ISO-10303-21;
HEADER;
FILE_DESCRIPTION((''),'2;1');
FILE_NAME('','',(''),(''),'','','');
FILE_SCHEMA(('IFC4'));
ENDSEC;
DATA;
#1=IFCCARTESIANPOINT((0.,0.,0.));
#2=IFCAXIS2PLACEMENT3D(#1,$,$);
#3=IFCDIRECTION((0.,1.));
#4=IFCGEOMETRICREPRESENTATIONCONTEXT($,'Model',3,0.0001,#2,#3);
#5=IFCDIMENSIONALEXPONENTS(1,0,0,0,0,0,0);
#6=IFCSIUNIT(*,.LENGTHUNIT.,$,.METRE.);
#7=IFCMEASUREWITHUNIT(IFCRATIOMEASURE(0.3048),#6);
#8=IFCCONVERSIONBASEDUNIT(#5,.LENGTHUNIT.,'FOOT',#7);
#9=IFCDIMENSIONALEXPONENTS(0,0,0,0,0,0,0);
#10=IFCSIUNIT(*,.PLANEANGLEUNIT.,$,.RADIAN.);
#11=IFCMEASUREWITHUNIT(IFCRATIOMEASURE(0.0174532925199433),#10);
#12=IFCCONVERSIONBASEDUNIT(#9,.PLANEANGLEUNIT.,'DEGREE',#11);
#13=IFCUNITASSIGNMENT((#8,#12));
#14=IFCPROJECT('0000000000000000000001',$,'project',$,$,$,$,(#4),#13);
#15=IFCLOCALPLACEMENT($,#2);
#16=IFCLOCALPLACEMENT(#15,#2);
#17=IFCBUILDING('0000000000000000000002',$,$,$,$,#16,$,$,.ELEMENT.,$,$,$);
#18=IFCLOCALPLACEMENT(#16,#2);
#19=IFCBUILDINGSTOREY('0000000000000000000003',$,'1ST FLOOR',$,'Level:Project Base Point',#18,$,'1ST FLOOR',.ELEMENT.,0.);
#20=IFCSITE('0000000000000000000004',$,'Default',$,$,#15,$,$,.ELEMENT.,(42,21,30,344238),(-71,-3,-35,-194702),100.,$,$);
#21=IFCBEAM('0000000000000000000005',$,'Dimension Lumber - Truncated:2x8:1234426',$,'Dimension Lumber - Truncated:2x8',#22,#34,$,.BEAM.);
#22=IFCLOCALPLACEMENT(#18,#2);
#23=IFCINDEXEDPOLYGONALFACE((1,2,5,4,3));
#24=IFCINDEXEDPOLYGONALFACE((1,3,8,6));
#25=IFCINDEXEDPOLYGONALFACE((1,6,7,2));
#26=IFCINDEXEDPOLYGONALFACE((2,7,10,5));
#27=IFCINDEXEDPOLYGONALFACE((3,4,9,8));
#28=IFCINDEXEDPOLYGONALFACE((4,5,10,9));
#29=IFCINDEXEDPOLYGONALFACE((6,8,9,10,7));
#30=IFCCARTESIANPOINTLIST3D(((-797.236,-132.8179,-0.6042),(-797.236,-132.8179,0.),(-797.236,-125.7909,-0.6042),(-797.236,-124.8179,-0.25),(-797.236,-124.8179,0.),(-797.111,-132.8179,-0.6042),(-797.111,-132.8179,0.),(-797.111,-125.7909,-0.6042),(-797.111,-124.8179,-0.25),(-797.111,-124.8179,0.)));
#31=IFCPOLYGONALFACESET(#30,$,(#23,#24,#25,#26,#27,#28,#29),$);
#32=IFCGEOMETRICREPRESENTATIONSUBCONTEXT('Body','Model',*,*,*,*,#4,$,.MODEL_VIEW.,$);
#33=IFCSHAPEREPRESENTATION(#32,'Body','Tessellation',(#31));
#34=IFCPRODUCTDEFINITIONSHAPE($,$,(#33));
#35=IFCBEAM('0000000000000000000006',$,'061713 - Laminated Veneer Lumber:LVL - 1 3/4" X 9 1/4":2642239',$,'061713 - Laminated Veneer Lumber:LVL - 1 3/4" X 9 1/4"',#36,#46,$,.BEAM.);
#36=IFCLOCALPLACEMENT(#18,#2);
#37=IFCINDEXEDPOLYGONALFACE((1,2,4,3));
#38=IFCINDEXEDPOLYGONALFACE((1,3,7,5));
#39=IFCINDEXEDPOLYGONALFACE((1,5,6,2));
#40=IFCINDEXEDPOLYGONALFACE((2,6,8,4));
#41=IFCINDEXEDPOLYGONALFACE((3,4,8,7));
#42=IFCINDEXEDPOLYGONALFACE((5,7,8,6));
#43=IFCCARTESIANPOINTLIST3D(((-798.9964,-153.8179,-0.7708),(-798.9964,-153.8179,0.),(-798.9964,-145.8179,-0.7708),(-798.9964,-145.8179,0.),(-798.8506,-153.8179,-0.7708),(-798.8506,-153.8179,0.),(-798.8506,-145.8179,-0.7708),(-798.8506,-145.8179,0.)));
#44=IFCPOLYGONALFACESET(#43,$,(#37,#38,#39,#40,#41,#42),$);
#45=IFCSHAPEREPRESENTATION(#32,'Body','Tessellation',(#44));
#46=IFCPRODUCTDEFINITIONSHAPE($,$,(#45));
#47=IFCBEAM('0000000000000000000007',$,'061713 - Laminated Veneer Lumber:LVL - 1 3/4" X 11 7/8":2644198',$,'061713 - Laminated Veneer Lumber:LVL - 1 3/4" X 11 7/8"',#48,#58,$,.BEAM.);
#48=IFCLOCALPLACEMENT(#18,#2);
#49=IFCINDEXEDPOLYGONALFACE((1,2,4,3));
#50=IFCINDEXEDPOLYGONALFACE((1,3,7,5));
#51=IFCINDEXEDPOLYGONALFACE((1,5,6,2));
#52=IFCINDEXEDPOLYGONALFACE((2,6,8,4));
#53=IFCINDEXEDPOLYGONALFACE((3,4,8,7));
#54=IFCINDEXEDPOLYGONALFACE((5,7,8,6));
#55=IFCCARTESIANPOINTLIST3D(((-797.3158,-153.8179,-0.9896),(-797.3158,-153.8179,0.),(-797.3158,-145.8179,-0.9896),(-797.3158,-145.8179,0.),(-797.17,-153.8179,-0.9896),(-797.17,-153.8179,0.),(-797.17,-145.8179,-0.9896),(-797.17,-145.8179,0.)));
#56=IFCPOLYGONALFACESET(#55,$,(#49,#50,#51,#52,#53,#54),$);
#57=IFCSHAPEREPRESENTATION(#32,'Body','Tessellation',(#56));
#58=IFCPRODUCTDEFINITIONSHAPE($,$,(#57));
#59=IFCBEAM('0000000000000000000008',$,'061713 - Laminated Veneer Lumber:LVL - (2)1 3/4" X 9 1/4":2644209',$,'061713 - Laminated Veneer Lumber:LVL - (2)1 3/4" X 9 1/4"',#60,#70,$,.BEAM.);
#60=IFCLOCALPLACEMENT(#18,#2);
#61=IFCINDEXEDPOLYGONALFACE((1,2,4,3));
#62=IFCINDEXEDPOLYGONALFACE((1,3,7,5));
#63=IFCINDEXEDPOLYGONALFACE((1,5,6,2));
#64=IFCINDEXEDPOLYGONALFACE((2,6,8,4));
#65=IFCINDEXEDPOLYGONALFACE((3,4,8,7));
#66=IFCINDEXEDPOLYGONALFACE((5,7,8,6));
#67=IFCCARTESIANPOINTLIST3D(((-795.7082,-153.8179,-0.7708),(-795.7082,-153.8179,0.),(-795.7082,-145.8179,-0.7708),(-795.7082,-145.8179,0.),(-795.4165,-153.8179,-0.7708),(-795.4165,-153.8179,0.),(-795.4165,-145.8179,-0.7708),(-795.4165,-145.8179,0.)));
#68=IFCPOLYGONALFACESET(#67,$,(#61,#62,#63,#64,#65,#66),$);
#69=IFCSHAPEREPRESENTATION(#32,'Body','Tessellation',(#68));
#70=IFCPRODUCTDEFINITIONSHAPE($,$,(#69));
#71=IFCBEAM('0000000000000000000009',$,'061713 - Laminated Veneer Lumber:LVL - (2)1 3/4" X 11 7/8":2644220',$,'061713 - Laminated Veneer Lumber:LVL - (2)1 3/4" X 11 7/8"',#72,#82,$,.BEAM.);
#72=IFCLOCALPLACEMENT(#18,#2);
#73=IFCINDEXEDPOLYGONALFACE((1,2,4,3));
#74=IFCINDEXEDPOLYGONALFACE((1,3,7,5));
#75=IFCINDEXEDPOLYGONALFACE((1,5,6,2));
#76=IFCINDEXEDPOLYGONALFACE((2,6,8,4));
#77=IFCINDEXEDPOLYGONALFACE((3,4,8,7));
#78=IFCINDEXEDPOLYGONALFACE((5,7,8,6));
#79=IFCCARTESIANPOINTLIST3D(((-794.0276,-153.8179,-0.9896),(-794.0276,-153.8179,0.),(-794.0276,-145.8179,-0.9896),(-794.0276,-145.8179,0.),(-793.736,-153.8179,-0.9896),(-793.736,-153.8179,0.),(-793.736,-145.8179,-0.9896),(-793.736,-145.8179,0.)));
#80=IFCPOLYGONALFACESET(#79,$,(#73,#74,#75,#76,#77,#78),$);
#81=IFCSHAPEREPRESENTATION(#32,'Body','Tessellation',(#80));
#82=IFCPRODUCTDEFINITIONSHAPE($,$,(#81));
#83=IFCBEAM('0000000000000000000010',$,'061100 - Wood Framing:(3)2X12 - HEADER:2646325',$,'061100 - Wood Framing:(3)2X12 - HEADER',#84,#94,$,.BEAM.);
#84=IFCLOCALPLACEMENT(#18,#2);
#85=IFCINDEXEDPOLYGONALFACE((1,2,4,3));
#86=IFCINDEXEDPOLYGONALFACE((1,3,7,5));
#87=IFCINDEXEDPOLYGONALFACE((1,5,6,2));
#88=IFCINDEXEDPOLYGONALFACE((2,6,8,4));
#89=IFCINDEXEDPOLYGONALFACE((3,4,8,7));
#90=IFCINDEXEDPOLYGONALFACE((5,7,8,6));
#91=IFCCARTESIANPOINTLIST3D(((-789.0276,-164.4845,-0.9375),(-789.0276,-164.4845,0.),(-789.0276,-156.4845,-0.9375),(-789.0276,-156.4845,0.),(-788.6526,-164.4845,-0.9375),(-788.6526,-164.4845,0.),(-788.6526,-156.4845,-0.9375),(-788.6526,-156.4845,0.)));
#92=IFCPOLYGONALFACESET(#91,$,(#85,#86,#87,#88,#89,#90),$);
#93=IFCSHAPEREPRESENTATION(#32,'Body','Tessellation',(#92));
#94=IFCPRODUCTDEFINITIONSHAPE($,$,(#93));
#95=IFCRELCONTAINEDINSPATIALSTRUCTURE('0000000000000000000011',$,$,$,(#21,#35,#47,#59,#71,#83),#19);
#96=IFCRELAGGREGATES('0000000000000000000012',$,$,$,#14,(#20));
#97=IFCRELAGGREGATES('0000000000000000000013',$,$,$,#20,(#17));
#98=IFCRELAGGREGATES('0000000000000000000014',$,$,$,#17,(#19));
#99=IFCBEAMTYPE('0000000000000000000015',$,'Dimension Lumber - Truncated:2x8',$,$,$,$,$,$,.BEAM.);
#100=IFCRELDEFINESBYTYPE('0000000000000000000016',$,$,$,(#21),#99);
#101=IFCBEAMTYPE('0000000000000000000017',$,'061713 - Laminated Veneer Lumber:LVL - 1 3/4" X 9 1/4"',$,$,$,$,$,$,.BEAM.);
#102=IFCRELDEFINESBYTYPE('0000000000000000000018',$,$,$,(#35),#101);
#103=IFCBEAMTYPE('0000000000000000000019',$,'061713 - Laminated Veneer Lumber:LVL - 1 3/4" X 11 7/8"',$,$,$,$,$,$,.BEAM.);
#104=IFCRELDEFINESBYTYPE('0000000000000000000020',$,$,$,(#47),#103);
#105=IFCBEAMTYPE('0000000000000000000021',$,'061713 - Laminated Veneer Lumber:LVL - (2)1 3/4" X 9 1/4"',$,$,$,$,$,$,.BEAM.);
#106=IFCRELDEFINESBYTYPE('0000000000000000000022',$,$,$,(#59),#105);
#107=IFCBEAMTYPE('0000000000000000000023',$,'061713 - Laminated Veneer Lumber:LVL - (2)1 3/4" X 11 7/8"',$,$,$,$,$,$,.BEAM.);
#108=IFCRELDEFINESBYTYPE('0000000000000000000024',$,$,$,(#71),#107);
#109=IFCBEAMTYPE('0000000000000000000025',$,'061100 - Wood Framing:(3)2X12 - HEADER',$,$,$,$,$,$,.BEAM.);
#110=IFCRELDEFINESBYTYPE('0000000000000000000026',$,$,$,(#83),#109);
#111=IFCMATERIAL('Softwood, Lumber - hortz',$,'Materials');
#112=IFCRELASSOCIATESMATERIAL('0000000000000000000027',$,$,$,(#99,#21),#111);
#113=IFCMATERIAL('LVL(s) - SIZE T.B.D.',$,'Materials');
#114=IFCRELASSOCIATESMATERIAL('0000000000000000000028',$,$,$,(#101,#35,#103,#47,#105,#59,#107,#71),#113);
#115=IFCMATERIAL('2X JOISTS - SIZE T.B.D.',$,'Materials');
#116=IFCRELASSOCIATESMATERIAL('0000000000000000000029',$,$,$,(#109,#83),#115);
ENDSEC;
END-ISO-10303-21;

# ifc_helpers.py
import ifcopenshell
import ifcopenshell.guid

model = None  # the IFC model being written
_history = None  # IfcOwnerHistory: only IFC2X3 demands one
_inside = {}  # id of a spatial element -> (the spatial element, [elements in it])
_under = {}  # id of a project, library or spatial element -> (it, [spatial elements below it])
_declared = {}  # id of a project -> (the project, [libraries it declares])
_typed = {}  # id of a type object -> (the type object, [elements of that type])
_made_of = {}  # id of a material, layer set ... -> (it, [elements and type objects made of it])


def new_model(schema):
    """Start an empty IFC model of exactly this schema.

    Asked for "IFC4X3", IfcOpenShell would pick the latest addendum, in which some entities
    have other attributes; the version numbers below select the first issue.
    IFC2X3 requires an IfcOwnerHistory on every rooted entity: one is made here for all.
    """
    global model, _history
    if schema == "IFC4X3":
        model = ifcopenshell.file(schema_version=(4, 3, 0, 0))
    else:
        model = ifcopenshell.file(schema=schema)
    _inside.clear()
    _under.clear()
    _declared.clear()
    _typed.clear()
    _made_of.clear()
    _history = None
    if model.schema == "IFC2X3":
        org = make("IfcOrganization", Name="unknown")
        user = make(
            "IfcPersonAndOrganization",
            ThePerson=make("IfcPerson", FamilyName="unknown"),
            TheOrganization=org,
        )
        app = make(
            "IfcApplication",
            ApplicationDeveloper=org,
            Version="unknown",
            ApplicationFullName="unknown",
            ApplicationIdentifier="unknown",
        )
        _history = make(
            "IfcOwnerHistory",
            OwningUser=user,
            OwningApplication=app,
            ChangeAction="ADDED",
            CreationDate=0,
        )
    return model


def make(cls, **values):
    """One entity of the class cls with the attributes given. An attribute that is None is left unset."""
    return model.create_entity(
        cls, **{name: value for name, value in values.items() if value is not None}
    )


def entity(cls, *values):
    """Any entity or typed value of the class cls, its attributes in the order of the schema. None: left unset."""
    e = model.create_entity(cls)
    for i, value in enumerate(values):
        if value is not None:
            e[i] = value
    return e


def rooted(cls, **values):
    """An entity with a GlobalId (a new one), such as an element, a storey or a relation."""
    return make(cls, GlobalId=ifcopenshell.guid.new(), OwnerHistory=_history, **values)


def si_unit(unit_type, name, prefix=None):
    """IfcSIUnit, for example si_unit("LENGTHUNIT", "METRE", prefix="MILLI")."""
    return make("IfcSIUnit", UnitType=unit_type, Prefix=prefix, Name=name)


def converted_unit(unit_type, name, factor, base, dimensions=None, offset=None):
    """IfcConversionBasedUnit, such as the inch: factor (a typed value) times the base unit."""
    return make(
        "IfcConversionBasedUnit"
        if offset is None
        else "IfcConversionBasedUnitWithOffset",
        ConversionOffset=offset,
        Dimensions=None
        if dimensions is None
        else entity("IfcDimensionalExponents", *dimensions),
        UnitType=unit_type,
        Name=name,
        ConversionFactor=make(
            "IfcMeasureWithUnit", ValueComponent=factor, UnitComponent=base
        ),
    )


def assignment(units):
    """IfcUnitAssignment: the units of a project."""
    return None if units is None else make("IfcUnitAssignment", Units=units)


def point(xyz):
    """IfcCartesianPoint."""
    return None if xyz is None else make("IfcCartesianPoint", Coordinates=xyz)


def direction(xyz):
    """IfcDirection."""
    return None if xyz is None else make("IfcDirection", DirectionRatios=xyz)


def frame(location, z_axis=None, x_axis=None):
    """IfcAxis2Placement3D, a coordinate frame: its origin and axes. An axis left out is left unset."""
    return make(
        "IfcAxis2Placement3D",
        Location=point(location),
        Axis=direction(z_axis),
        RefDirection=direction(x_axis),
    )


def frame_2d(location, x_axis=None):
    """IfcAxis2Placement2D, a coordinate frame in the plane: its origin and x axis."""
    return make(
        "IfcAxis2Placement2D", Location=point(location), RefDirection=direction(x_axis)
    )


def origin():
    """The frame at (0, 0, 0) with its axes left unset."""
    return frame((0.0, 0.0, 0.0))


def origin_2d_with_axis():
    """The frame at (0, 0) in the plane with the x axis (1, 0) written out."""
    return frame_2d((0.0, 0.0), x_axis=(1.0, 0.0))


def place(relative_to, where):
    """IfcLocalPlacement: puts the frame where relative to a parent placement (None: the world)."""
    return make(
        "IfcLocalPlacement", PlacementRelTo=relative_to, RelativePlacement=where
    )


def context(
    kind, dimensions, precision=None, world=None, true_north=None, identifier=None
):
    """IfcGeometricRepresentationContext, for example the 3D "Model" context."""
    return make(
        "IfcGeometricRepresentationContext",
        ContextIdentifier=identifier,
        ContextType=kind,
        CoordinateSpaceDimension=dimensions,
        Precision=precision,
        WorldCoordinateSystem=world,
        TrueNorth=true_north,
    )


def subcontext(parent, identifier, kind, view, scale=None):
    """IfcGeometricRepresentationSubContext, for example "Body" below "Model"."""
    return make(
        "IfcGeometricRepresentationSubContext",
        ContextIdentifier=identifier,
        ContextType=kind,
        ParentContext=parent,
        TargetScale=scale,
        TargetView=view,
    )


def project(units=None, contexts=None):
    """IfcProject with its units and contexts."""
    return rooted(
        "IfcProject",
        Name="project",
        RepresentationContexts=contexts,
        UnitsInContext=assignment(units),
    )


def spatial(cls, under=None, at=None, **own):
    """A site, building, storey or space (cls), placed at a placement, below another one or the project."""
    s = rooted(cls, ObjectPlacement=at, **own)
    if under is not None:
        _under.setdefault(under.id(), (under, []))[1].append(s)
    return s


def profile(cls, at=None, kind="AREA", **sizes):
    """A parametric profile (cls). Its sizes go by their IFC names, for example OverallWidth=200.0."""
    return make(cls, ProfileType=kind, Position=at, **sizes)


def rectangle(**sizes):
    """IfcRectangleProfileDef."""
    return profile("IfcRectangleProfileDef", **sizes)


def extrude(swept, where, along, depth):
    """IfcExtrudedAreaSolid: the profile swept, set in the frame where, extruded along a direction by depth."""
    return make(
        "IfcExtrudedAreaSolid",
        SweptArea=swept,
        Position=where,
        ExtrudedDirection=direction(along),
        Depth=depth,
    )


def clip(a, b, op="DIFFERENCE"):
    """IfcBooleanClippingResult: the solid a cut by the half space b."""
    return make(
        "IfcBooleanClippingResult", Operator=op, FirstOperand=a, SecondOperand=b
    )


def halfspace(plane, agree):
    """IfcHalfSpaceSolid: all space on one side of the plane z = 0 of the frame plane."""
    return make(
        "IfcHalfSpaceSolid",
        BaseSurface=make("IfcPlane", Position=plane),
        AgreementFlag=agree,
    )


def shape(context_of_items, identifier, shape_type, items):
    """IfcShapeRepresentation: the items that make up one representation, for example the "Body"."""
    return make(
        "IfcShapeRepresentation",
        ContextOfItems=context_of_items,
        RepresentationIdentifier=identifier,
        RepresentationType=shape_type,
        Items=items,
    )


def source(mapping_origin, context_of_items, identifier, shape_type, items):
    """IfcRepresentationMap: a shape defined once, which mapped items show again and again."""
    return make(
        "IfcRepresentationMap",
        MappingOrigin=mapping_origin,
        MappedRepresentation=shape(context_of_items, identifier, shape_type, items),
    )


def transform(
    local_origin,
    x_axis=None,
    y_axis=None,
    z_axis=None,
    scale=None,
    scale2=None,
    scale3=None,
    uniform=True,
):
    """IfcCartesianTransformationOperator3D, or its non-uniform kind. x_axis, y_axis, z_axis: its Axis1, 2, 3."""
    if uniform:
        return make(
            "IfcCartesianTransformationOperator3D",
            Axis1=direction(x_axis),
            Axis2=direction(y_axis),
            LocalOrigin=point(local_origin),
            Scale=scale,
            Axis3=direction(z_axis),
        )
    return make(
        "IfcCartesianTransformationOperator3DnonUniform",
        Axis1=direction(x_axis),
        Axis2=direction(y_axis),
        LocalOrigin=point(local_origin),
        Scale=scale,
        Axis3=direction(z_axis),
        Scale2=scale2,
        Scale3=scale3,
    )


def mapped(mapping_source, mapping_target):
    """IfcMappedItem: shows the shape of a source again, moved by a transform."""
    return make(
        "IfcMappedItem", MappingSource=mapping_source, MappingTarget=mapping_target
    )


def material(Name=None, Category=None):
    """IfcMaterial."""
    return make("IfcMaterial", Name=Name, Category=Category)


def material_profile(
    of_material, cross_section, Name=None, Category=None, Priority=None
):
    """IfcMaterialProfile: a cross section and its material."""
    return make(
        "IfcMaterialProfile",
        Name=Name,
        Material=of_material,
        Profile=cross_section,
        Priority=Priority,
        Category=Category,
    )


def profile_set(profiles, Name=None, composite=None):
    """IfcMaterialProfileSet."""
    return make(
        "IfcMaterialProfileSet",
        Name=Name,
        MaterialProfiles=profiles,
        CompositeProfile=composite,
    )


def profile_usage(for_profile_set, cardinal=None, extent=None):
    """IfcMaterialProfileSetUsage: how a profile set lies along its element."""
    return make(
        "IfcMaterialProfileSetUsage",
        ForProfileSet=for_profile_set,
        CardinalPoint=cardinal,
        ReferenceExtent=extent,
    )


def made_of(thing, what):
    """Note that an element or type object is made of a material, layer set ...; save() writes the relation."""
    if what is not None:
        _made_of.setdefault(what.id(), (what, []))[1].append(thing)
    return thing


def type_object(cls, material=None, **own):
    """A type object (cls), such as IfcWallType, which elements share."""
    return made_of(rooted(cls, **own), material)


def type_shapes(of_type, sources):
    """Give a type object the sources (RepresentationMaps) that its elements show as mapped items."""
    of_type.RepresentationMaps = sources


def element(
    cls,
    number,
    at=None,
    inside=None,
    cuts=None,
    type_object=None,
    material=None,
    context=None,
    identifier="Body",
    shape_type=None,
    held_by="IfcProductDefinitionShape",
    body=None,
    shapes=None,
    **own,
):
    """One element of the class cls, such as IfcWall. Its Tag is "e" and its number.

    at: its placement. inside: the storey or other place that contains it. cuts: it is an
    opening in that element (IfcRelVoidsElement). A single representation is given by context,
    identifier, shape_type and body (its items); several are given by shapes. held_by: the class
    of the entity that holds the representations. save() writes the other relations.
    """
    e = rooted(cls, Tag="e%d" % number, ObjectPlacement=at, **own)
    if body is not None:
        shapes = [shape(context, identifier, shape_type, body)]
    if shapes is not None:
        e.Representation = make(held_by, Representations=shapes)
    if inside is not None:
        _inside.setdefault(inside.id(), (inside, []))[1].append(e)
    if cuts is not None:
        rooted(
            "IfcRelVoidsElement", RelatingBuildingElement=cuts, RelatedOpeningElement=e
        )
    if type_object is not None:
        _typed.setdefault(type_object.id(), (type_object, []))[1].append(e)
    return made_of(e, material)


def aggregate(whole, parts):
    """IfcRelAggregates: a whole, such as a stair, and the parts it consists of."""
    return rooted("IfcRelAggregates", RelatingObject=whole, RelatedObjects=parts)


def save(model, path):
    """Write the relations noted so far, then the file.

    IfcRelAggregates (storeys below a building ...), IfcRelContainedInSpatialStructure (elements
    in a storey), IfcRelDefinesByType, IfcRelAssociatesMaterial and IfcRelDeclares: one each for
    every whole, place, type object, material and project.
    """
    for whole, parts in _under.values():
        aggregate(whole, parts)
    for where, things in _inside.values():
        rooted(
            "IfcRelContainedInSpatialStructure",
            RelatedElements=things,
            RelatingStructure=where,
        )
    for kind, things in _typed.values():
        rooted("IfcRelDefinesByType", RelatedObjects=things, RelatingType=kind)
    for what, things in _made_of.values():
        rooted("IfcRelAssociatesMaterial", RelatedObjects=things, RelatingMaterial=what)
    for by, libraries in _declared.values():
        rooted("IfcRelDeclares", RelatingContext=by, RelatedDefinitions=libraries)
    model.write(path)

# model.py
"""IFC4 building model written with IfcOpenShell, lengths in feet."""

from ifc_helpers import new_model, entity, si_unit, converted_unit, direction, frame, frame_2d, origin, origin_2d_with_axis, place, context, subcontext, project, spatial, rectangle, extrude, clip, halfspace, source, transform, mapped, material, material_profile, profile_set, profile_usage, type_object, type_shapes, element, save


model = new_model("IFC4")

# Units and contexts
model_context = context("Model", 3, precision=0.0001, world=origin(), true_north=direction((0.0, 1.0)))
body_context = subcontext(model_context, "Body", "Model", "MODEL_VIEW")
ifc_project = project(units=[converted_unit("LENGTHUNIT", "FOOT", entity("IfcRatioMeasure", 0.3048), si_unit("LENGTHUNIT", "METRE"), dimensions=[1, 0, 0, 0, 0, 0, 0]), converted_unit("PLANEANGLEUNIT", "DEGREE", entity("IfcRatioMeasure", 0.0174532925199433), si_unit("PLANEANGLEUNIT", "RADIAN"), dimensions=[0, 0, 0, 0, 0, 0, 0])], contexts=[model_context])

# Site, building, storey
site_placement = place(None, origin())
site = spatial("IfcSite", under=ifc_project, at=site_placement, Name="Default", CompositionType="ELEMENT", RefLatitude=(42, 21, 30, 344238), RefLongitude=(-71, -3, -35, -194702), RefElevation=100.0)
building_placement = place(site_placement, origin())
building = spatial("IfcBuilding", under=site, at=building_placement, CompositionType="ELEMENT")
storey_placement = place(building_placement, origin())
storey = spatial("IfcBuildingStorey", under=building, at=storey_placement, Name="1ST FLOOR", ObjectType="Level:Project Base Point", LongName="1ST FLOOR", CompositionType="ELEMENT", Elevation=0.0)

# Beams
ifc_material_1 = material(Name="Softwood, Lumber - hortz", Category="Materials")
ifc_material_profile_1 = material_profile(ifc_material_1, rectangle(XDim=0.6042, YDim=0.125, at=frame_2d((0.0, 0.0), x_axis=(0.0, 1.0))), Name="2x8")
ifc_profile_set_1 = profile_set([ifc_material_profile_1], Name="2x8")
ifc_profile_usage_1 = profile_usage(ifc_profile_set_1, cardinal=8)
beam_type_1 = type_object("IfcBeamType", Name="Dimension Lumber - Truncated:2x8", PredefinedType="BEAM", material=ifc_profile_set_1)
shared_shape_1 = source(origin(), body_context, "Body", "Clipping", [
    clip(extrude(rectangle(XDim=0.6042, YDim=0.125, at=frame_2d((0.0, 0.0), x_axis=(0.0, 1.0))), frame((-4.0, 0.0, 0.0), z_axis=(1.0, 0.0, 0.0), x_axis=(0.0, 1.0, 0.0)), (0.0, 0.0, 1.0), 8.0), halfspace(frame((-3.0269, -0.0625, -0.3021), z_axis=(-0.34202, 0.0, -0.939693), x_axis=(0.0, 1.0, 0.0)), False)),
])
type_shapes(beam_type_1, [shared_shape_1])
beam_1_placement = place(storey_placement, frame((-797.1735, -128.8179, -0.3021), z_axis=(0.0, 0.0, 1.0), x_axis=(0.0, -1.0, 0.0)))
element("IfcBeam", 1, at=beam_1_placement, inside=storey, type_object=beam_type_1, material=ifc_profile_usage_1, Name="Dimension Lumber - Truncated:2x8:1234426", ObjectType="Dimension Lumber - Truncated:2x8", PredefinedType="BEAM", context=body_context, shape_type="MappedRepresentation", body=[
    mapped(shared_shape_1, transform((0.0, 0.0, 0.0), scale=1.0)),
])
ifc_material_2 = material(Name="LVL(s) - SIZE T.B.D.", Category="Materials")
ifc_material_profile_2 = material_profile(ifc_material_2, rectangle(XDim=0.7708, YDim=0.1458, at=origin_2d_with_axis()), Name="LVL - 1 3/4\" X 9 1/4\"")
ifc_profile_set_2 = profile_set([ifc_material_profile_2], Name="LVL - 1 3/4\" X 9 1/4\"")
ifc_profile_usage_2 = profile_usage(ifc_profile_set_2, cardinal=8)
beam_type_2 = type_object("IfcBeamType", Name="061713 - Laminated Veneer Lumber:LVL - 1 3/4\" X 9 1/4\"", PredefinedType="BEAM", material=ifc_profile_set_2)
shared_shape_2 = source(origin(), body_context, "Body", "SweptSolid", [
    extrude(rectangle(XDim=0.7708, YDim=0.1458, at=origin_2d_with_axis()), frame((-4.0, 0.0, 0.0), z_axis=(1.0, 0.0, 0.0), x_axis=(0.0, 0.0, -1.0)), (0.0, 0.0, 1.0), 8.0),
])
type_shapes(beam_type_2, [shared_shape_2])
beam_2_placement = place(storey_placement, frame((-798.9235, -149.8179, -0.3854), z_axis=(0.0, 0.0, 1.0), x_axis=(0.0, -1.0, 0.0)))
element("IfcBeam", 2, at=beam_2_placement, inside=storey, type_object=beam_type_2, material=ifc_profile_usage_2, Name="061713 - Laminated Veneer Lumber:LVL - 1 3/4\" X 9 1/4\":2642239", ObjectType="061713 - Laminated Veneer Lumber:LVL - 1 3/4\" X 9 1/4\"", PredefinedType="BEAM", context=body_context, shape_type="MappedRepresentation", body=[
    mapped(shared_shape_2, transform((0.0, 0.0, 0.0), scale=1.0)),
])
ifc_material_profile_3 = material_profile(ifc_material_2, rectangle(XDim=0.9896, YDim=0.1458, at=origin_2d_with_axis()), Name="LVL - 1 3/4\" X 11 7/8\"")
ifc_profile_set_3 = profile_set([ifc_material_profile_3], Name="LVL - 1 3/4\" X 11 7/8\"")
ifc_profile_usage_3 = profile_usage(ifc_profile_set_3, cardinal=8)
beam_type_3 = type_object("IfcBeamType", Name="061713 - Laminated Veneer Lumber:LVL - 1 3/4\" X 11 7/8\"", PredefinedType="BEAM", material=ifc_profile_set_3)
shared_shape_3 = source(origin(), body_context, "Body", "SweptSolid", [
    extrude(rectangle(XDim=0.9896, YDim=0.1458, at=origin_2d_with_axis()), frame((-4.0, 0.0, 0.0), z_axis=(1.0, 0.0, 0.0), x_axis=(0.0, 0.0, -1.0)), (0.0, 0.0, 1.0), 8.0),
])
type_shapes(beam_type_3, [shared_shape_3])
beam_3_placement = place(storey_placement, frame((-797.2429, -149.8179, -0.4948), z_axis=(0.0, 0.0, 1.0), x_axis=(0.0, -1.0, 0.0)))
element("IfcBeam", 3, at=beam_3_placement, inside=storey, type_object=beam_type_3, material=ifc_profile_usage_3, Name="061713 - Laminated Veneer Lumber:LVL - 1 3/4\" X 11 7/8\":2644198", ObjectType="061713 - Laminated Veneer Lumber:LVL - 1 3/4\" X 11 7/8\"", PredefinedType="BEAM", context=body_context, shape_type="MappedRepresentation", body=[
    mapped(shared_shape_3, transform((0.0, 0.0, 0.0), scale=1.0)),
])
ifc_material_profile_4 = material_profile(ifc_material_2, rectangle(XDim=0.7708, YDim=0.2917, at=origin_2d_with_axis()), Name="LVL - (2)1 3/4\" X 9 1/4\"")
ifc_profile_set_4 = profile_set([ifc_material_profile_4], Name="LVL - (2)1 3/4\" X 9 1/4\"")
ifc_profile_usage_4 = profile_usage(ifc_profile_set_4, cardinal=8)
beam_type_4 = type_object("IfcBeamType", Name="061713 - Laminated Veneer Lumber:LVL - (2)1 3/4\" X 9 1/4\"", PredefinedType="BEAM", material=ifc_profile_set_4)
shared_shape_4 = source(origin(), body_context, "Body", "SweptSolid", [
    extrude(rectangle(XDim=0.7708, YDim=0.2917, at=origin_2d_with_axis()), frame((-4.0, 0.0, 0.0), z_axis=(1.0, 0.0, 0.0), x_axis=(0.0, 0.0, -1.0)), (0.0, 0.0, 1.0), 8.0),
])
type_shapes(beam_type_4, [shared_shape_4])
beam_4_placement = place(storey_placement, frame((-795.5624, -149.8179, -0.3854), z_axis=(0.0, 0.0, 1.0), x_axis=(0.0, -1.0, 0.0)))
element("IfcBeam", 4, at=beam_4_placement, inside=storey, type_object=beam_type_4, material=ifc_profile_usage_4, Name="061713 - Laminated Veneer Lumber:LVL - (2)1 3/4\" X 9 1/4\":2644209", ObjectType="061713 - Laminated Veneer Lumber:LVL - (2)1 3/4\" X 9 1/4\"", PredefinedType="BEAM", context=body_context, shape_type="MappedRepresentation", body=[
    mapped(shared_shape_4, transform((0.0, 0.0, 0.0), scale=1.0)),
])
ifc_material_profile_5 = material_profile(ifc_material_2, rectangle(XDim=0.9896, YDim=0.2917, at=origin_2d_with_axis()), Name="LVL - (2)1 3/4\" X 11 7/8\"")
ifc_profile_set_5 = profile_set([ifc_material_profile_5], Name="LVL - (2)1 3/4\" X 11 7/8\"")
ifc_profile_usage_5 = profile_usage(ifc_profile_set_5, cardinal=8)
beam_type_5 = type_object("IfcBeamType", Name="061713 - Laminated Veneer Lumber:LVL - (2)1 3/4\" X 11 7/8\"", PredefinedType="BEAM", material=ifc_profile_set_5)
shared_shape_5 = source(origin(), body_context, "Body", "SweptSolid", [
    extrude(rectangle(XDim=0.9896, YDim=0.2917, at=origin_2d_with_axis()), frame((-4.0, 0.0, 0.0), z_axis=(1.0, 0.0, 0.0), x_axis=(0.0, 0.0, -1.0)), (0.0, 0.0, 1.0), 8.0),
])
type_shapes(beam_type_5, [shared_shape_5])
beam_5_placement = place(storey_placement, frame((-793.8818, -149.8179, -0.4948), z_axis=(0.0, 0.0, 1.0), x_axis=(0.0, -1.0, 0.0)))
element("IfcBeam", 5, at=beam_5_placement, inside=storey, type_object=beam_type_5, material=ifc_profile_usage_5, Name="061713 - Laminated Veneer Lumber:LVL - (2)1 3/4\" X 11 7/8\":2644220", ObjectType="061713 - Laminated Veneer Lumber:LVL - (2)1 3/4\" X 11 7/8\"", PredefinedType="BEAM", context=body_context, shape_type="MappedRepresentation", body=[
    mapped(shared_shape_5, transform((0.0, 0.0, 0.0), scale=1.0)),
])
ifc_material_3 = material(Name="2X JOISTS - SIZE T.B.D.", Category="Materials")
ifc_material_profile_6 = material_profile(ifc_material_3, rectangle(XDim=0.9375, YDim=0.375, at=origin_2d_with_axis()), Name="(3)2X12 - HEADER")
ifc_profile_set_6 = profile_set([ifc_material_profile_6], Name="(3)2X12 - HEADER")
ifc_profile_usage_6 = profile_usage(ifc_profile_set_6, cardinal=8)
beam_type_6 = type_object("IfcBeamType", Name="061100 - Wood Framing:(3)2X12 - HEADER", PredefinedType="BEAM", material=ifc_profile_set_6)
shared_shape_6 = source(origin(), body_context, "Body", "SweptSolid", [
    extrude(rectangle(XDim=0.9375, YDim=0.375, at=origin_2d_with_axis()), frame((-4.0, 0.0, 0.0), z_axis=(1.0, 0.0, 0.0), x_axis=(0.0, 0.0, -1.0)), (0.0, 0.0, 1.0), 8.0),
])
type_shapes(beam_type_6, [shared_shape_6])
beam_6_placement = place(storey_placement, frame((-788.8401, -160.4845, -0.4687), z_axis=(0.0, 0.0, 1.0), x_axis=(0.0, -1.0, 0.0)))
element("IfcBeam", 6, at=beam_6_placement, inside=storey, type_object=beam_type_6, material=ifc_profile_usage_6, Name="061100 - Wood Framing:(3)2X12 - HEADER:2646325", ObjectType="061100 - Wood Framing:(3)2X12 - HEADER", PredefinedType="BEAM", context=body_context, shape_type="MappedRepresentation", body=[
    mapped(shared_shape_6, transform((0.0, 0.0, 0.0), scale=1.0)),
])

save(model, "model.ifc")
